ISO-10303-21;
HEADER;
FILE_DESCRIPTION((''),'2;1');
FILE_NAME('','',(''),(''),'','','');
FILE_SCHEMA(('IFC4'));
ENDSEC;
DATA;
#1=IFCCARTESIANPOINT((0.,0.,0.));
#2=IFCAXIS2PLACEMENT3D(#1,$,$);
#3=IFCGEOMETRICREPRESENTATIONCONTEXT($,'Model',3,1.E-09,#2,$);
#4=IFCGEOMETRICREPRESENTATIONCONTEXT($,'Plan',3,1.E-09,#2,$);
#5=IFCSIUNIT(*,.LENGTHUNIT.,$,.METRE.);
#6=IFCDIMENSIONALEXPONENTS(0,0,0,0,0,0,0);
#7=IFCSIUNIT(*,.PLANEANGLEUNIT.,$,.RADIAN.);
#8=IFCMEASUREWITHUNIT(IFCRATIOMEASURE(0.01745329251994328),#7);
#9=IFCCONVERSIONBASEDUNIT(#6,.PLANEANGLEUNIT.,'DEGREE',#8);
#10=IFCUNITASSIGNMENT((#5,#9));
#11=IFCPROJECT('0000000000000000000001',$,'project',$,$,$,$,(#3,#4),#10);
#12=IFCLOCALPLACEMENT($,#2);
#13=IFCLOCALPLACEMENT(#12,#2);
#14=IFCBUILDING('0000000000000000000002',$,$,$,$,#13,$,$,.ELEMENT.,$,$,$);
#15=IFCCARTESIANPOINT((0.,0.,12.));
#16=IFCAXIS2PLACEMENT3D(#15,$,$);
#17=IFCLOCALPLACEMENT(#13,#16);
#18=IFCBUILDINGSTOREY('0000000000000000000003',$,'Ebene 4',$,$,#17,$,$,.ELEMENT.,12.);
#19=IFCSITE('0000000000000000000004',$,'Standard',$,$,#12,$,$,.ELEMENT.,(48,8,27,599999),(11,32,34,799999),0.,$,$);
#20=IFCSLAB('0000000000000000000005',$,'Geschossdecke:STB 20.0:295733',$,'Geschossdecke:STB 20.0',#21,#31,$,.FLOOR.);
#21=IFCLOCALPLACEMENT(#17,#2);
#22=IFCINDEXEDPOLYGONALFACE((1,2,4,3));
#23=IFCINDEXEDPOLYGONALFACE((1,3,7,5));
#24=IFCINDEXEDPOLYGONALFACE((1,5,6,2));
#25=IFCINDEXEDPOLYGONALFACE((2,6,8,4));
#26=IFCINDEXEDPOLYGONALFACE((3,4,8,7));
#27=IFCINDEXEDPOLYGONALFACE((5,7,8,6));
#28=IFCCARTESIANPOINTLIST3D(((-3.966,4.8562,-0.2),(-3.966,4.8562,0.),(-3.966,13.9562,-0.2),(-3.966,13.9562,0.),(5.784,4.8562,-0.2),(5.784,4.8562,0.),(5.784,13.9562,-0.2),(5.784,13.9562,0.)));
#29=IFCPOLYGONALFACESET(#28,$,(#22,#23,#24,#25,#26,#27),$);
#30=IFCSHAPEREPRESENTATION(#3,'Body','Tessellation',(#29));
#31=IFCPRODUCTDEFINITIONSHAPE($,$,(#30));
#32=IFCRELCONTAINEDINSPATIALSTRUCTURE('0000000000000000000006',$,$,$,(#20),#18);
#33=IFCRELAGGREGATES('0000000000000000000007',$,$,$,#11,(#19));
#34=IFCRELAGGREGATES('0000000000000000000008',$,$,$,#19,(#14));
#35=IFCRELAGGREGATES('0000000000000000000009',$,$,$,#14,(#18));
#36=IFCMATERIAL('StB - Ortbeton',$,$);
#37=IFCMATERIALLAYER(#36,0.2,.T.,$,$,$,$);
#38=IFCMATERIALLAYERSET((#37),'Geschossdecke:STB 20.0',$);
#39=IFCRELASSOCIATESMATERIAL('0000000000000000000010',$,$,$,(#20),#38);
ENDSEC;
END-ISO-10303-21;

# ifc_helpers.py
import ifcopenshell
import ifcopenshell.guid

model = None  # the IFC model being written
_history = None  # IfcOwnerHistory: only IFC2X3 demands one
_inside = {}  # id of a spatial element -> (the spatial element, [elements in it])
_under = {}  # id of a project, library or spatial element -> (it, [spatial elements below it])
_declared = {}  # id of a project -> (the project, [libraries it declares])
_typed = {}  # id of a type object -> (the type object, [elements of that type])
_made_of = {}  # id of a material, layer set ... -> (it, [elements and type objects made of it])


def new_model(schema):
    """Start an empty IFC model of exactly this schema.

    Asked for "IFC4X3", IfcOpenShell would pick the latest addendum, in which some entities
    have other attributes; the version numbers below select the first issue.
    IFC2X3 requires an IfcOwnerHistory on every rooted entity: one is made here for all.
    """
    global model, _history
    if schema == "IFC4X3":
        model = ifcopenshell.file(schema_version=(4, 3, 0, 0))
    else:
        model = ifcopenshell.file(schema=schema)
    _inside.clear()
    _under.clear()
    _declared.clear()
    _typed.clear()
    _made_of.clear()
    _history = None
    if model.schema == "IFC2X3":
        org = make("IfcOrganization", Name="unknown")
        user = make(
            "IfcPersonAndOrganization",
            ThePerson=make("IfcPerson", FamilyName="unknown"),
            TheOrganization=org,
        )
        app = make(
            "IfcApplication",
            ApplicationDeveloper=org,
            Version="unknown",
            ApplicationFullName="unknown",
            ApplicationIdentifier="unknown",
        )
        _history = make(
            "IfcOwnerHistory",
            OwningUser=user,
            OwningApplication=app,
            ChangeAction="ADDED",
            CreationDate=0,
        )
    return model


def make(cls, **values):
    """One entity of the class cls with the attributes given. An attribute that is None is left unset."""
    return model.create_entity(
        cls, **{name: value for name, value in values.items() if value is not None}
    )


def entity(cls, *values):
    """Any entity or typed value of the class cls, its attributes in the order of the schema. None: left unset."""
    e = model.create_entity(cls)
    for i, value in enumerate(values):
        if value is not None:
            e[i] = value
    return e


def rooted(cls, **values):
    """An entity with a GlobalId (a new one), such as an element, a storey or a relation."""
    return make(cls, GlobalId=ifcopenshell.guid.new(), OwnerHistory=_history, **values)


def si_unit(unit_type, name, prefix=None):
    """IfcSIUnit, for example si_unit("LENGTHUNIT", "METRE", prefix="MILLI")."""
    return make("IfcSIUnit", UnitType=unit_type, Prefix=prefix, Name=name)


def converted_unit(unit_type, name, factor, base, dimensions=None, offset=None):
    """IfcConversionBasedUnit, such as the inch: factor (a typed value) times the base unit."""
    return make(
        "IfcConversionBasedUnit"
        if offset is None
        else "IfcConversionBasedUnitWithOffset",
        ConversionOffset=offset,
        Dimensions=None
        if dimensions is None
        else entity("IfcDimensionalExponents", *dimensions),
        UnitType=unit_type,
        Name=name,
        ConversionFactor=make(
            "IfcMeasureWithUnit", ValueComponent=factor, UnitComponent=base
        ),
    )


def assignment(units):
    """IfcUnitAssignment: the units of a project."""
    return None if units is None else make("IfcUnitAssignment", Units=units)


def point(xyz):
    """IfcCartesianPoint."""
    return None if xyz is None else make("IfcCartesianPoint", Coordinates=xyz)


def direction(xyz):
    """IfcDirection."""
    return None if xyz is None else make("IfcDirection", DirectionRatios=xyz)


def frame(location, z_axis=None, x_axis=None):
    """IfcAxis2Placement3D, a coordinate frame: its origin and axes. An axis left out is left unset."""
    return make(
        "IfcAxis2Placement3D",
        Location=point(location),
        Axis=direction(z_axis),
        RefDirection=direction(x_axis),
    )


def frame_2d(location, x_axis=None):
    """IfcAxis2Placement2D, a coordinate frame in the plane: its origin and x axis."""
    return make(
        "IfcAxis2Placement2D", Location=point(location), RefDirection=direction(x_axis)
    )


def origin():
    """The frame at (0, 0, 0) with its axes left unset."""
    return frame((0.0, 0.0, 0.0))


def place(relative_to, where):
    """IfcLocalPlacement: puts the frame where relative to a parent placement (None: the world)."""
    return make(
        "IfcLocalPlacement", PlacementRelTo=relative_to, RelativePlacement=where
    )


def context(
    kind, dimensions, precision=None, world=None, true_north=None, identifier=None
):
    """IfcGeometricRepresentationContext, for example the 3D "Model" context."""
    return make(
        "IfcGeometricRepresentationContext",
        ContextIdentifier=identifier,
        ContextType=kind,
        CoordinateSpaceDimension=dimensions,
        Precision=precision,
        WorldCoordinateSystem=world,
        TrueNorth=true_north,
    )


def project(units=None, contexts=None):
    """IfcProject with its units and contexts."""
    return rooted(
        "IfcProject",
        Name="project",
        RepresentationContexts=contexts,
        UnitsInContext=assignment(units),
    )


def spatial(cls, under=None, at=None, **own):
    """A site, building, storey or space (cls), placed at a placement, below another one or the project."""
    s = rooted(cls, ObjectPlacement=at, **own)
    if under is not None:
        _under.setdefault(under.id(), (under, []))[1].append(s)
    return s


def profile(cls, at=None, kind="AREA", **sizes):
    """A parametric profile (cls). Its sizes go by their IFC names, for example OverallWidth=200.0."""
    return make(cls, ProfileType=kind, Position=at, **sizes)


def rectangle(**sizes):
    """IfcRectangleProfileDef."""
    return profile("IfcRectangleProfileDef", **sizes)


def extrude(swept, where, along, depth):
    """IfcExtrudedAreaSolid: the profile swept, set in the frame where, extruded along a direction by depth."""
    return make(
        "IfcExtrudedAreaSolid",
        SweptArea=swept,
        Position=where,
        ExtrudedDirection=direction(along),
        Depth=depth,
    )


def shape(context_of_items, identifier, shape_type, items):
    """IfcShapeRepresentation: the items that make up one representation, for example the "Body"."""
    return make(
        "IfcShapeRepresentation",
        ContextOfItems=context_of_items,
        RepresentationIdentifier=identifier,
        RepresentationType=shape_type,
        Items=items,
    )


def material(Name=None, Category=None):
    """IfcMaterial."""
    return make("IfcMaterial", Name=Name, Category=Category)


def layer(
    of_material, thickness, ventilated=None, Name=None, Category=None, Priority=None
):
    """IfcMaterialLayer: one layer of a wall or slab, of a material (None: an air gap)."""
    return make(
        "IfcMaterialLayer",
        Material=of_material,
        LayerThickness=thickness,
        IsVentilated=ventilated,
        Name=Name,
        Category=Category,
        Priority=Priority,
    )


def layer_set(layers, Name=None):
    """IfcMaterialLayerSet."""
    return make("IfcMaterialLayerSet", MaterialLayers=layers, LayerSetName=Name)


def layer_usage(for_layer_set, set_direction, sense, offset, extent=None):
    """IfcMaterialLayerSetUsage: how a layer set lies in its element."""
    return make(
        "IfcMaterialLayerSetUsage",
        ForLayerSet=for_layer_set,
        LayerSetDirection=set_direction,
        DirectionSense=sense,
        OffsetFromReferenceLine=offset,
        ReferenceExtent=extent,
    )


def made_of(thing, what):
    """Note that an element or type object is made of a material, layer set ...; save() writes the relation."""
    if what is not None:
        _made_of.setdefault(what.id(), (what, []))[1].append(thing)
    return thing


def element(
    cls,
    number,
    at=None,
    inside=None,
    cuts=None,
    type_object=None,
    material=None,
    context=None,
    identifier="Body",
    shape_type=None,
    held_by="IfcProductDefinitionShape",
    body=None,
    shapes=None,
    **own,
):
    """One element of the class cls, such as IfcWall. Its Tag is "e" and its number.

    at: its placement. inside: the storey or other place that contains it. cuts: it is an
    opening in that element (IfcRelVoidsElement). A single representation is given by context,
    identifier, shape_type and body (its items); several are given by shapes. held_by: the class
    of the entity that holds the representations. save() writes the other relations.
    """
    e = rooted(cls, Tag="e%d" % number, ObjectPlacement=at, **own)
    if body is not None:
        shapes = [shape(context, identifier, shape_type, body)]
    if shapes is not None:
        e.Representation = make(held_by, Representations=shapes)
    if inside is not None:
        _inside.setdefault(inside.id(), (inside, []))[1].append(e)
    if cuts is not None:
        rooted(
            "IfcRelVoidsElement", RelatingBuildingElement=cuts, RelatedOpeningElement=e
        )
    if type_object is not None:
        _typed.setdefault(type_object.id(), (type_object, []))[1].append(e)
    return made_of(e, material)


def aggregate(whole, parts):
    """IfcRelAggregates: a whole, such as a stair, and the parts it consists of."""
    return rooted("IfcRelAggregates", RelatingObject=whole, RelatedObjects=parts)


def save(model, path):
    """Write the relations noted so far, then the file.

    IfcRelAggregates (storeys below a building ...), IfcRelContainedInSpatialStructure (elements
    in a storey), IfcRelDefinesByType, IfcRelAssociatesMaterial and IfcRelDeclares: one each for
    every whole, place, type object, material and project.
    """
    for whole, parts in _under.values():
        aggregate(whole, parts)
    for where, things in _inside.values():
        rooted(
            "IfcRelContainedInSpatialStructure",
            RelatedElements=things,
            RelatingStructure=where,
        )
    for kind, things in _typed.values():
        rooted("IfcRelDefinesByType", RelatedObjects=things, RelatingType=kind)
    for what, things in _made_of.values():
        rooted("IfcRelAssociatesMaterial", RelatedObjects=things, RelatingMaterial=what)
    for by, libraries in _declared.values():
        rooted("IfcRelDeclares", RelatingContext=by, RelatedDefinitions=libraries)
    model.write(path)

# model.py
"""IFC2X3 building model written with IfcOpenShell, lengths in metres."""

from ifc_helpers import new_model, entity, si_unit, converted_unit, frame, frame_2d, origin, place, context, project, spatial, rectangle, extrude, material, layer, layer_set, layer_usage, element, save


model = new_model("IFC2X3")

# Units and contexts
model_context = context("Model", 3, precision=1e-09, world=origin())
plan_context = context("Plan", 3, precision=1e-09, world=origin())
ifc_project = project(units=[si_unit("LENGTHUNIT", "METRE"), converted_unit("PLANEANGLEUNIT", "DEGREE", entity("IfcRatioMeasure", 0.01745329251994328), si_unit("PLANEANGLEUNIT", "RADIAN"), dimensions=[0, 0, 0, 0, 0, 0, 0])], contexts=[model_context, plan_context])

# Site, building, storey
site_placement = place(None, origin())
site = spatial("IfcSite", under=ifc_project, at=site_placement, Name="Standard", CompositionType="ELEMENT", RefLatitude=(48, 8, 27, 599999), RefLongitude=(11, 32, 34, 799999), RefElevation=0.0)
building_placement = place(site_placement, origin())
building = spatial("IfcBuilding", under=site, at=building_placement, CompositionType="ELEMENT")
storey_placement = place(building_placement, frame((0.0, 0.0, 12.0)))
storey = spatial("IfcBuildingStorey", under=building, at=storey_placement, Name="Ebene 4", CompositionType="ELEMENT", Elevation=12.0)

# Slab
ifc_material = material(Name="StB - Ortbeton")
ifc_layer = layer(ifc_material, 0.2, ventilated=True)
ifc_layer_set = layer_set([ifc_layer], Name="Geschossdecke:STB 20.0")
ifc_layer_usage = layer_usage(ifc_layer_set, "AXIS3", "POSITIVE", 0.0)
slab_placement = place(storey_placement, frame((-3.966, 4.8562, -0.2)))
element("IfcSlab", 1, at=slab_placement, inside=storey, material=ifc_layer_usage, Name="Geschossdecke:STB 20.0:295733", ObjectType="Geschossdecke:STB 20.0", PredefinedType="FLOOR", context=model_context, shape_type="SweptSolid", body=[
    extrude(rectangle(XDim=9.1, YDim=9.75, at=frame_2d((0.0, 0.0), x_axis=(0.0, -1.0))), frame((4.875, 4.55, 0.2), z_axis=(0.0, 0.0, -1.0), x_axis=(-1.0, 0.0, 0.0)), (0.0, 0.0, 1.0), 0.2),
])

save(model, "model.ifc")
